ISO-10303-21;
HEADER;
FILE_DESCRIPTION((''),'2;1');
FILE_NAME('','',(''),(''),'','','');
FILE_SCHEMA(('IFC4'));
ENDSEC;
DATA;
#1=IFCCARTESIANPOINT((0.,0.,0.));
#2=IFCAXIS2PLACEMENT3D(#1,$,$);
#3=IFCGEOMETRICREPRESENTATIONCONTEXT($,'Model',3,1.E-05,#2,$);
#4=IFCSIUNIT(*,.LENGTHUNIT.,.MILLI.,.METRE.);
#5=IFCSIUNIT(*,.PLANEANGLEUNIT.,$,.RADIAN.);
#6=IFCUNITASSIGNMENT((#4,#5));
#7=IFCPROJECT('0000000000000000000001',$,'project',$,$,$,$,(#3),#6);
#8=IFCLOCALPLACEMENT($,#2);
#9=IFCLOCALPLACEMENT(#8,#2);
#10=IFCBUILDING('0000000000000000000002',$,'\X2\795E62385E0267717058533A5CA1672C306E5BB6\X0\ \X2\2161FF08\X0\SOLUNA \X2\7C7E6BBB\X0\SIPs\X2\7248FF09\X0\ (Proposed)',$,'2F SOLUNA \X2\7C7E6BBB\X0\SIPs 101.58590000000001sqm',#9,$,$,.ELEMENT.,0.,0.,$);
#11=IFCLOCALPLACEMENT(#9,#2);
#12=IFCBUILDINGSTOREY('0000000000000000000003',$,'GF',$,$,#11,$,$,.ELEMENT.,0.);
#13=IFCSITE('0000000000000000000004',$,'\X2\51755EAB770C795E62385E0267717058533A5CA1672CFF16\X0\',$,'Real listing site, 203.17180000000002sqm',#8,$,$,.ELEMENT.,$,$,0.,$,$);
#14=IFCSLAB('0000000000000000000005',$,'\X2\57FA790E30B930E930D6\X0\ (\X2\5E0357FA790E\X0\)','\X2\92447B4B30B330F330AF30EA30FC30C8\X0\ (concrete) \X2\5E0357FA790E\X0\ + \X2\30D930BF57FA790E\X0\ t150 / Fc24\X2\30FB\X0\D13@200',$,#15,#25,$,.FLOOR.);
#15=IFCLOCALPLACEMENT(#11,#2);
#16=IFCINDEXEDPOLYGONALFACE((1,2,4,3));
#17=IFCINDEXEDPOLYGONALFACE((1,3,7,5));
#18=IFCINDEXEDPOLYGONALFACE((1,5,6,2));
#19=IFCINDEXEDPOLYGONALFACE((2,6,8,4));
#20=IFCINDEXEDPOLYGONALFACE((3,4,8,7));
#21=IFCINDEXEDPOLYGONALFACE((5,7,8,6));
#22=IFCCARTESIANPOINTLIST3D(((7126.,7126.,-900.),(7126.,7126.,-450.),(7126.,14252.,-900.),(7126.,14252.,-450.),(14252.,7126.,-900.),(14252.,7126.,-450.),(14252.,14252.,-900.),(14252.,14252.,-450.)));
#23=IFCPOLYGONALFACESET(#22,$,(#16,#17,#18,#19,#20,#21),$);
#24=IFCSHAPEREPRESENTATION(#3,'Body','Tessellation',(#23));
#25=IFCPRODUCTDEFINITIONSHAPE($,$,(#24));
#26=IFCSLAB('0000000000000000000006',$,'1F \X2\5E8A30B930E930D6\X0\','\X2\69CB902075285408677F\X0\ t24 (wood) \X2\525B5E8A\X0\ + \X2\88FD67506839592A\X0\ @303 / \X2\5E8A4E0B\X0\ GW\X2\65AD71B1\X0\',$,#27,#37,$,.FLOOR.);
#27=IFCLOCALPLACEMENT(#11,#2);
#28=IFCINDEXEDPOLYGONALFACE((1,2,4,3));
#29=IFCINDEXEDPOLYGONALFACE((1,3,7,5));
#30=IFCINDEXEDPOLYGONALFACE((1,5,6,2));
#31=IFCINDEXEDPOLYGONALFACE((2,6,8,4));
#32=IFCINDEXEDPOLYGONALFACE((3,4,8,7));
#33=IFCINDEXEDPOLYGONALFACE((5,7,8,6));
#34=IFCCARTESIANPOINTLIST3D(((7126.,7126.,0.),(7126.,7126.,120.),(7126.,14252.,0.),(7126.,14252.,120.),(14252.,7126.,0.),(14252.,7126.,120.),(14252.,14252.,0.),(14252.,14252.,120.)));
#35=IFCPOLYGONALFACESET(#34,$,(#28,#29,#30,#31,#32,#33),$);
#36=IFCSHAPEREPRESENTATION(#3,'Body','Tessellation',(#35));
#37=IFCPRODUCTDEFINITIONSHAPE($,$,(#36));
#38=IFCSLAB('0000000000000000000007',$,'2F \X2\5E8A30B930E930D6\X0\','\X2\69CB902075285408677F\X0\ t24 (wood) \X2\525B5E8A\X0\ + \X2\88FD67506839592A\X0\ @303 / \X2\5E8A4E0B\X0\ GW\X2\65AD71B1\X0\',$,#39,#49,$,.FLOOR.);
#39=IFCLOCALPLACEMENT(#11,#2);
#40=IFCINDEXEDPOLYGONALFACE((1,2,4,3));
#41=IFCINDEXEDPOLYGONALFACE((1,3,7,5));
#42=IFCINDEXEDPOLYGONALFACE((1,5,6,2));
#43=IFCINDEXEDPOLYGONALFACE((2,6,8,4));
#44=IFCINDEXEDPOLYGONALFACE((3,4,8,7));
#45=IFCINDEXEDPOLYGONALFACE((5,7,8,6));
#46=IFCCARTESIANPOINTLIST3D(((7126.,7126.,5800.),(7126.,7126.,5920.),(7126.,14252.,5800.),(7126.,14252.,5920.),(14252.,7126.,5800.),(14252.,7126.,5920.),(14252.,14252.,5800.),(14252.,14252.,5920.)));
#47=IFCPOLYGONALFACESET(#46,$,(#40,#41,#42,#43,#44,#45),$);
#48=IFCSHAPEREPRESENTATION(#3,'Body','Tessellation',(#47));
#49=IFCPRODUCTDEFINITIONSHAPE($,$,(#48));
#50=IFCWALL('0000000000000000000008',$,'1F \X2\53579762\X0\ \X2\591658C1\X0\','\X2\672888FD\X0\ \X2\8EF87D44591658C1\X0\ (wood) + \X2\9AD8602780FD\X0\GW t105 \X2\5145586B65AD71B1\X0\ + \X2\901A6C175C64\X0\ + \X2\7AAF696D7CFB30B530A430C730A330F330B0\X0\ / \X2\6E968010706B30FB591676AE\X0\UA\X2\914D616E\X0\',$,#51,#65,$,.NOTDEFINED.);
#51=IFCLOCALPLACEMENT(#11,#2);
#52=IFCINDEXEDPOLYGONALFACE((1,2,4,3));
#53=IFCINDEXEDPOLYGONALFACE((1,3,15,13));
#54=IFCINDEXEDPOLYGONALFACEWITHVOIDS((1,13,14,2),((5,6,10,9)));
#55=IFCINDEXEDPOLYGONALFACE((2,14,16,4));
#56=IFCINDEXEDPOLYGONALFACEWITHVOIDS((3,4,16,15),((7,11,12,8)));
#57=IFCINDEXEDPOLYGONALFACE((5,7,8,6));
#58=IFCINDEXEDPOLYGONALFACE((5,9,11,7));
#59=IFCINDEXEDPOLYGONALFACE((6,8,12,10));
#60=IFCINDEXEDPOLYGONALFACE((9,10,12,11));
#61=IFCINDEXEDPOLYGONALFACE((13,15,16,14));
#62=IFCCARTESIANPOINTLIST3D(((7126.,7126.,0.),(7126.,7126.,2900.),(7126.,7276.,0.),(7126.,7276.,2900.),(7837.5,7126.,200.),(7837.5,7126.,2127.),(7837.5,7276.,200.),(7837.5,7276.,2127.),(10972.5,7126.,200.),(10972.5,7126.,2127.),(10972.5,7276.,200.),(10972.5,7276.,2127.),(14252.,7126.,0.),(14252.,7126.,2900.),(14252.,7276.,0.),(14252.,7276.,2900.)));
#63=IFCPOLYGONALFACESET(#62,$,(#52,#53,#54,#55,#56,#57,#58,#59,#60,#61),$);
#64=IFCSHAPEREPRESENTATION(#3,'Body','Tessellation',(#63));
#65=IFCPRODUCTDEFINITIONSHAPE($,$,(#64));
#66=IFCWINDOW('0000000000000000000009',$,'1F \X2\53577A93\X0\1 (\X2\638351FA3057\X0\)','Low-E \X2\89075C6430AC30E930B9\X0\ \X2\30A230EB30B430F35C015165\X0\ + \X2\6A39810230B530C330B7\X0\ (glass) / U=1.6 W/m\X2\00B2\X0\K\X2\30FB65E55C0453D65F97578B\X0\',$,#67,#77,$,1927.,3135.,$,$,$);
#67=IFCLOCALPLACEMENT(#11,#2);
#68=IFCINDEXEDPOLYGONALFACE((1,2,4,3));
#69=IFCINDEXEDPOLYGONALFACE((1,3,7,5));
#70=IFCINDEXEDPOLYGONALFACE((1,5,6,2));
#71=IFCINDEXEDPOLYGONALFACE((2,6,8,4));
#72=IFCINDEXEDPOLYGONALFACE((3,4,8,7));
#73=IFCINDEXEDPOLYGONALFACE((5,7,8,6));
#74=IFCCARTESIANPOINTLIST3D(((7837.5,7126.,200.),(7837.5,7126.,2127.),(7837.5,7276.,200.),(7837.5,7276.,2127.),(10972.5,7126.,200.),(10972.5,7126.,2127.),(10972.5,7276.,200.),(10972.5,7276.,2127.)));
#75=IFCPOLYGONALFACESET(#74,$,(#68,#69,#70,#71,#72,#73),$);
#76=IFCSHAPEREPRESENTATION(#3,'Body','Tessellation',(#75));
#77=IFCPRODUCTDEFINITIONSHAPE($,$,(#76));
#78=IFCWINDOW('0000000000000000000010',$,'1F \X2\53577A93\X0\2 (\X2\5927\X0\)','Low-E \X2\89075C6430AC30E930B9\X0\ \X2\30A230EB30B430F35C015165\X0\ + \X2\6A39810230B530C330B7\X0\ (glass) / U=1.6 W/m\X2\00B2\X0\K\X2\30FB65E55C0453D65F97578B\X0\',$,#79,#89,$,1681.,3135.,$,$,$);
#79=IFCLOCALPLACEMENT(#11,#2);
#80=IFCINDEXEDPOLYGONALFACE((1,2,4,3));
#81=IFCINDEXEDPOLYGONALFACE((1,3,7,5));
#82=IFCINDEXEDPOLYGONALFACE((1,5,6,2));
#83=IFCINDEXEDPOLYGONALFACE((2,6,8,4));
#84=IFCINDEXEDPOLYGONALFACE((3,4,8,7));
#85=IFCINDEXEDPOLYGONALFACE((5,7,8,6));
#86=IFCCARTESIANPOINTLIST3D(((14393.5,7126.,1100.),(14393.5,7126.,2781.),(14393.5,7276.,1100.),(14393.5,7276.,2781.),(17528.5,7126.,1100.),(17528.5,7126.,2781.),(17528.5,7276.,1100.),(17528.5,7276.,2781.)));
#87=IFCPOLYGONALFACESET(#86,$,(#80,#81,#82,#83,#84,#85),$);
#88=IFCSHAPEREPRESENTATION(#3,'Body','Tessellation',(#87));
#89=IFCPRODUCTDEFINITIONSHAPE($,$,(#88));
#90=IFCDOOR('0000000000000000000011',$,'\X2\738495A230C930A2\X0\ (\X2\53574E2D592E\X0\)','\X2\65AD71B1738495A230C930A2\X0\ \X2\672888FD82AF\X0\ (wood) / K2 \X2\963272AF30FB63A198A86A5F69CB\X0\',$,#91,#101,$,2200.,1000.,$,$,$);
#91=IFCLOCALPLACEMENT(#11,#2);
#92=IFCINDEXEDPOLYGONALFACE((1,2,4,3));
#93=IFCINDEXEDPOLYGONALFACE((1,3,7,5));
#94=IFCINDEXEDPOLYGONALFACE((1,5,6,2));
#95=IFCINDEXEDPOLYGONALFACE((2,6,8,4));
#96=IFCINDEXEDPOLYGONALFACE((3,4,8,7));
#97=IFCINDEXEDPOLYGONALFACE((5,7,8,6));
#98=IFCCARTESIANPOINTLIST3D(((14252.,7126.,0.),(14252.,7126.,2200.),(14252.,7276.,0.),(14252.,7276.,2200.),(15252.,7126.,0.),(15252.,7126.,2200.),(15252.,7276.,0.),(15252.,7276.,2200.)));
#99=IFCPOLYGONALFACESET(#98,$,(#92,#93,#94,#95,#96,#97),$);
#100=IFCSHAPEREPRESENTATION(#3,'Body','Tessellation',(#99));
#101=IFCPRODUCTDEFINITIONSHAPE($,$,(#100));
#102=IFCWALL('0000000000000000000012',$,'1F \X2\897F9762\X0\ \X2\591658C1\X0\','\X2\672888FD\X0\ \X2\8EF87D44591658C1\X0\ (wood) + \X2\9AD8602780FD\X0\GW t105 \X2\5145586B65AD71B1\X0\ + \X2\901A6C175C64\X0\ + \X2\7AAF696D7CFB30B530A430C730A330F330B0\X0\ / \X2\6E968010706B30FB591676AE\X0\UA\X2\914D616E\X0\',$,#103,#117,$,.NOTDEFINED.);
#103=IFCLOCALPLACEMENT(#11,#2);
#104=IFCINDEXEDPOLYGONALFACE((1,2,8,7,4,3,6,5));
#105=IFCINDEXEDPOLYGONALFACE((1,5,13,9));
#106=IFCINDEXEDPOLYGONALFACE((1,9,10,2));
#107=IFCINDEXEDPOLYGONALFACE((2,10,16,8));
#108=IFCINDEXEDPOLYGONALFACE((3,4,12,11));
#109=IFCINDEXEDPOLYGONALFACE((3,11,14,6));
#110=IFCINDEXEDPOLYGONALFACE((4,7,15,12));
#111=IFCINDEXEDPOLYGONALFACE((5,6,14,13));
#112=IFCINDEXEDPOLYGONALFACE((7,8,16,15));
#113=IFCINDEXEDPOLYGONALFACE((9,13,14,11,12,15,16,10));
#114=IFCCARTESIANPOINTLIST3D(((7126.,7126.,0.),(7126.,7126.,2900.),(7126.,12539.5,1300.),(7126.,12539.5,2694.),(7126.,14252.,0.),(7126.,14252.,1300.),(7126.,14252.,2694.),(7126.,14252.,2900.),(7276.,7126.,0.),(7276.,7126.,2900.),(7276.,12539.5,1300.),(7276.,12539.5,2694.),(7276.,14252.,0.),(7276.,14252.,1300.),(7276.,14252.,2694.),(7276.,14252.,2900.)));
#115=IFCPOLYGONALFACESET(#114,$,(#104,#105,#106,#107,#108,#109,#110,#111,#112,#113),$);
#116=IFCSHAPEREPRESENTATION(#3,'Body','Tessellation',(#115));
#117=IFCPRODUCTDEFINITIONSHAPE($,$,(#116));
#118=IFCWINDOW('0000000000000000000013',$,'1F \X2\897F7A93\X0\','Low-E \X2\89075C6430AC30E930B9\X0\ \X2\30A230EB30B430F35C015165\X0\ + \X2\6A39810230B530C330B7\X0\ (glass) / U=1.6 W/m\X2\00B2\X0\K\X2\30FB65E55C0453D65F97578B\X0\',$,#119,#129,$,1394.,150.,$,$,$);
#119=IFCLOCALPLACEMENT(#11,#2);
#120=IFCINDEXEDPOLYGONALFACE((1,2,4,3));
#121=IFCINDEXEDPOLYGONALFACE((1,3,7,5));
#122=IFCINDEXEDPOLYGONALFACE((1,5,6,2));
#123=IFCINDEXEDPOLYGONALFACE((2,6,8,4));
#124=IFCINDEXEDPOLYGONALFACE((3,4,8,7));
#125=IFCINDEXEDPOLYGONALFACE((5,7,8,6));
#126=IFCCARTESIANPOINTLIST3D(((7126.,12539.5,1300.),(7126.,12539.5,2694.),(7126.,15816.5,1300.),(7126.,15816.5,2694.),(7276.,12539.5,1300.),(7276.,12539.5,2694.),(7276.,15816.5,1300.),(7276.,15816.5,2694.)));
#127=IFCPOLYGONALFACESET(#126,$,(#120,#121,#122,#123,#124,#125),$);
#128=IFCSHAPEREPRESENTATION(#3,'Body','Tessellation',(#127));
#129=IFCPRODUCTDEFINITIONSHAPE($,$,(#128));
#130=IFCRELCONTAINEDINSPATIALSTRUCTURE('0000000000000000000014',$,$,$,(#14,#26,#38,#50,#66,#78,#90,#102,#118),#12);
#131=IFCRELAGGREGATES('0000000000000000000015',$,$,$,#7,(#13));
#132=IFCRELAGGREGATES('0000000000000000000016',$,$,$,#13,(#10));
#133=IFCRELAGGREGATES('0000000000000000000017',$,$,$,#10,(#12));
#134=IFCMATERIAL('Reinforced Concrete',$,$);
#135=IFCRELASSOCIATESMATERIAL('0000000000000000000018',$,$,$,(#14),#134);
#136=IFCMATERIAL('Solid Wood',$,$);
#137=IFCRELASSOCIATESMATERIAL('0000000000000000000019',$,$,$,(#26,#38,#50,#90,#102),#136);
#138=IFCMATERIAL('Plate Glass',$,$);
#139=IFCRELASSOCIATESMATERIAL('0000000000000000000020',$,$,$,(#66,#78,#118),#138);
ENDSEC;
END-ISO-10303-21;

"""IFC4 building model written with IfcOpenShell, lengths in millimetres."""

from ifc_helpers import new_model, si_unit, frame, frame_2d, origin, place, context, project, spatial, rectangle, extrude, material, element, fill, save


model = new_model("IFC4")

# Units and contexts
model_context = context("Model", 3, precision=1e-05, world=origin())
ifc_project = project(units=[si_unit("LENGTHUNIT", "METRE", prefix="MILLI"), si_unit("PLANEANGLEUNIT", "RADIAN")], contexts=[model_context])

# Site, building, storey
site_placement = place(None, origin())
site = spatial("IfcSite", under=ifc_project, at=site_placement, Name="兵庫県神戸市東灘区岡本６", ObjectType="Real listing site, 203.17180000000002sqm", CompositionType="ELEMENT", RefElevation=0.0)
building_placement = place(site_placement, origin())
building = spatial("IfcBuilding", under=site, at=building_placement, Name="神戸市東灘区岡本の家 Ⅱ（SOLUNA 籾殻SIPs版） (Proposed)", ObjectType="2F SOLUNA 籾殻SIPs 101.58590000000001sqm", CompositionType="ELEMENT", ElevationOfRefHeight=0.0, ElevationOfTerrain=0.0)
storey_placement = place(building_placement, origin())
storey = spatial("IfcBuildingStorey", under=building, at=storey_placement, Name="GF", CompositionType="ELEMENT", Elevation=0.0)

# Slabs
ifc_material_1 = material(Name="Reinforced Concrete")
slab_1_placement = place(storey_placement, frame((3563.0, 3563.0, -450.0)))
element("IfcSlab", 1, at=slab_1_placement, inside=storey, material=ifc_material_1, Name="基礎スラブ (布基礎)", Description="鉄筋コンクリート (concrete) 布基礎 + ベタ基礎 t150 / Fc24・D13@200", PredefinedType="FLOOR", context=model_context, shape_type="SweptSolid", body=[
    extrude(rectangle(XDim=7126.0, YDim=7126.0, at=frame_2d((3563.0, 3563.0))), frame((3563.0, 3563.0, -450.0)), (0.0, 0.0, 1.0), 450.0),
])
ifc_material_2 = material(Name="Solid Wood")
slab_2_placement = place(storey_placement, frame((3563.0, 3563.0, 0.0)))
element("IfcSlab", 2, at=slab_2_placement, inside=storey, material=ifc_material_2, Name="1F 床スラブ", Description="構造用合板 t24 (wood) 剛床 + 製材根太 @303 / 床下 GW断熱", PredefinedType="FLOOR", context=model_context, shape_type="SweptSolid", body=[
    extrude(rectangle(XDim=7126.0, YDim=7126.0, at=frame_2d((3563.0, 3563.0))), frame((3563.0, 3563.0, 0.0)), (0.0, 0.0, 1.0), 120.0),
])
slab_3_placement = place(storey_placement, frame((3563.0, 3563.0, 2900.0)))
element("IfcSlab", 3, at=slab_3_placement, inside=storey, material=ifc_material_2, Name="2F 床スラブ", Description="構造用合板 t24 (wood) 剛床 + 製材根太 @303 / 床下 GW断熱", PredefinedType="FLOOR", context=model_context, shape_type="SweptSolid", body=[
    extrude(rectangle(XDim=7126.0, YDim=7126.0, at=frame_2d((3563.0, 3563.0))), frame((3563.0, 3563.0, 2900.0)), (0.0, 0.0, 1.0), 120.0),
])

# Wall, openings, windows, door
wall_1_placement = place(storey_placement, frame((3563.0, 3563.0, 0.0)))
wall_1 = element("IfcWall", 4, at=wall_1_placement, inside=storey, material=ifc_material_2, Name="1F 南面 外壁", Description="木製 軸組外壁 (wood) + 高性能GW t105 充填断熱 + 通気層 + 窯業系サイディング / 準耐火・外皮UA配慮", PredefinedType="NOTDEFINED", context=model_context, shape_type="SweptSolid", body=[
    extrude(rectangle(XDim=7126.0, YDim=150.0, at=frame_2d((3563.0, 75.0))), frame((3563.0, 3563.0, 0.0)), (0.0, 0.0, 1.0), 2900.0),
])
opening_1_placement = place(storey_placement, frame((3919.0, 3563.0, 100.0)))
opening_1 = element("IfcOpeningElement", 5, at=opening_1_placement, cuts=wall_1, PredefinedType="NOTDEFINED", context=model_context, shape_type="SweptSolid", body=[
    extrude(rectangle(XDim=3135.0, YDim=150.0, at=frame_2d((1567.0, 75.0))), frame((3919.0, 3563.0, 100.0)), (0.0, 0.0, 1.0), 1927.0),
])
opening_2_placement = place(storey_placement, frame((7197.0, 3563.0, 550.0)))
opening_2 = element("IfcOpeningElement", 6, at=opening_2_placement, cuts=wall_1, PredefinedType="NOTDEFINED", context=model_context, shape_type="SweptSolid", body=[
    extrude(rectangle(XDim=3135.0, YDim=150.0, at=frame_2d((1567.0, 75.0))), frame((7197.0, 3563.0, 550.0)), (0.0, 0.0, 1.0), 1681.0),
])
opening_3_placement = place(storey_placement, frame((7126.0, 3563.0, 0.0)))
opening_3 = element("IfcOpeningElement", 7, at=opening_3_placement, cuts=wall_1, PredefinedType="NOTDEFINED", context=model_context, shape_type="SweptSolid", body=[
    extrude(rectangle(XDim=1000.0, YDim=150.0, at=frame_2d((500.0, 75.0))), frame((7126.0, 3563.0, 0.0)), (0.0, 0.0, 1.0), 2200.0),
])
ifc_material_3 = material(Name="Plate Glass")
window_1_placement = place(storey_placement, frame((3919.0, 3563.0, 100.0)))
window_1 = element("IfcWindow", 8, at=window_1_placement, inside=storey, material=ifc_material_3, Name="1F 南窓1 (掃出し)", Description="Low-E 複層ガラス アルゴン封入 + 樹脂サッシ (glass) / U=1.6 W/m²K・日射取得型", OverallHeight=1927.0, OverallWidth=3135.0, context=model_context, shape_type="SweptSolid", body=[
    extrude(rectangle(XDim=3135.0, YDim=150.0, at=frame_2d((1567.0, 75.0))), frame((3919.0, 3563.0, 100.0)), (0.0, 0.0, 1.0), 1927.0),
])
fill(opening_1, window_1)
window_2_placement = place(storey_placement, frame((7197.0, 3563.0, 550.0)))
window_2 = element("IfcWindow", 9, at=window_2_placement, inside=storey, material=ifc_material_3, Name="1F 南窓2 (大)", Description="Low-E 複層ガラス アルゴン封入 + 樹脂サッシ (glass) / U=1.6 W/m²K・日射取得型", OverallHeight=1681.0, OverallWidth=3135.0, context=model_context, shape_type="SweptSolid", body=[
    extrude(rectangle(XDim=3135.0, YDim=150.0, at=frame_2d((1567.0, 75.0))), frame((7197.0, 3563.0, 550.0)), (0.0, 0.0, 1.0), 1681.0),
])
fill(opening_2, window_2)
door_placement = place(storey_placement, frame((7126.0, 3563.0, 0.0)))
door = element("IfcDoor", 10, at=door_placement, inside=storey, material=ifc_material_2, Name="玄関ドア (南中央)", Description="断熱玄関ドア 木製芯 (wood) / K2 防犯・採風機構", OverallHeight=2200.0, OverallWidth=1000.0, context=model_context, shape_type="SweptSolid", body=[
    extrude(rectangle(XDim=1000.0, YDim=150.0, at=frame_2d((500.0, 75.0))), frame((7126.0, 3563.0, 0.0)), (0.0, 0.0, 1.0), 2200.0),
])
fill(opening_3, door)

# Wall, opening, window
wall_2_placement = place(storey_placement, frame((3563.0, 3563.0, 0.0)))
wall_2 = element("IfcWall", 11, at=wall_2_placement, inside=storey, material=ifc_material_2, Name="1F 西面 外壁", Description="木製 軸組外壁 (wood) + 高性能GW t105 充填断熱 + 通気層 + 窯業系サイディング / 準耐火・外皮UA配慮", PredefinedType="NOTDEFINED", context=model_context, shape_type="SweptSolid", body=[
    extrude(rectangle(XDim=150.0, YDim=7126.0, at=frame_2d((75.0, 3563.0))), frame((3563.0, 3563.0, 0.0)), (0.0, 0.0, 1.0), 2900.0),
])
opening_4_placement = place(storey_placement, frame((3563.0, 6270.0, 650.0)))
opening_4 = element("IfcOpeningElement", 12, at=opening_4_placement, cuts=wall_2, PredefinedType="NOTDEFINED", context=model_context, shape_type="SweptSolid", body=[
    extrude(rectangle(XDim=150.0, YDim=3277.0, at=frame_2d((75.0, 1638.0))), frame((3563.0, 6270.0, 650.0)), (0.0, 0.0, 1.0), 1394.0),
])
window_3_placement = place(storey_placement, frame((3563.0, 6270.0, 650.0)))
window_3 = element("IfcWindow", 13, at=window_3_placement, inside=storey, material=ifc_material_3, Name="1F 西窓", Description="Low-E 複層ガラス アルゴン封入 + 樹脂サッシ (glass) / U=1.6 W/m²K・日射取得型", OverallHeight=1394.0, OverallWidth=150.0, context=model_context, shape_type="SweptSolid", body=[
    extrude(rectangle(XDim=150.0, YDim=3277.0, at=frame_2d((75.0, 1638.0))), frame((3563.0, 6270.0, 650.0)), (0.0, 0.0, 1.0), 1394.0),
])
fill(opening_4, window_3)

save(model, "model.ifc")
